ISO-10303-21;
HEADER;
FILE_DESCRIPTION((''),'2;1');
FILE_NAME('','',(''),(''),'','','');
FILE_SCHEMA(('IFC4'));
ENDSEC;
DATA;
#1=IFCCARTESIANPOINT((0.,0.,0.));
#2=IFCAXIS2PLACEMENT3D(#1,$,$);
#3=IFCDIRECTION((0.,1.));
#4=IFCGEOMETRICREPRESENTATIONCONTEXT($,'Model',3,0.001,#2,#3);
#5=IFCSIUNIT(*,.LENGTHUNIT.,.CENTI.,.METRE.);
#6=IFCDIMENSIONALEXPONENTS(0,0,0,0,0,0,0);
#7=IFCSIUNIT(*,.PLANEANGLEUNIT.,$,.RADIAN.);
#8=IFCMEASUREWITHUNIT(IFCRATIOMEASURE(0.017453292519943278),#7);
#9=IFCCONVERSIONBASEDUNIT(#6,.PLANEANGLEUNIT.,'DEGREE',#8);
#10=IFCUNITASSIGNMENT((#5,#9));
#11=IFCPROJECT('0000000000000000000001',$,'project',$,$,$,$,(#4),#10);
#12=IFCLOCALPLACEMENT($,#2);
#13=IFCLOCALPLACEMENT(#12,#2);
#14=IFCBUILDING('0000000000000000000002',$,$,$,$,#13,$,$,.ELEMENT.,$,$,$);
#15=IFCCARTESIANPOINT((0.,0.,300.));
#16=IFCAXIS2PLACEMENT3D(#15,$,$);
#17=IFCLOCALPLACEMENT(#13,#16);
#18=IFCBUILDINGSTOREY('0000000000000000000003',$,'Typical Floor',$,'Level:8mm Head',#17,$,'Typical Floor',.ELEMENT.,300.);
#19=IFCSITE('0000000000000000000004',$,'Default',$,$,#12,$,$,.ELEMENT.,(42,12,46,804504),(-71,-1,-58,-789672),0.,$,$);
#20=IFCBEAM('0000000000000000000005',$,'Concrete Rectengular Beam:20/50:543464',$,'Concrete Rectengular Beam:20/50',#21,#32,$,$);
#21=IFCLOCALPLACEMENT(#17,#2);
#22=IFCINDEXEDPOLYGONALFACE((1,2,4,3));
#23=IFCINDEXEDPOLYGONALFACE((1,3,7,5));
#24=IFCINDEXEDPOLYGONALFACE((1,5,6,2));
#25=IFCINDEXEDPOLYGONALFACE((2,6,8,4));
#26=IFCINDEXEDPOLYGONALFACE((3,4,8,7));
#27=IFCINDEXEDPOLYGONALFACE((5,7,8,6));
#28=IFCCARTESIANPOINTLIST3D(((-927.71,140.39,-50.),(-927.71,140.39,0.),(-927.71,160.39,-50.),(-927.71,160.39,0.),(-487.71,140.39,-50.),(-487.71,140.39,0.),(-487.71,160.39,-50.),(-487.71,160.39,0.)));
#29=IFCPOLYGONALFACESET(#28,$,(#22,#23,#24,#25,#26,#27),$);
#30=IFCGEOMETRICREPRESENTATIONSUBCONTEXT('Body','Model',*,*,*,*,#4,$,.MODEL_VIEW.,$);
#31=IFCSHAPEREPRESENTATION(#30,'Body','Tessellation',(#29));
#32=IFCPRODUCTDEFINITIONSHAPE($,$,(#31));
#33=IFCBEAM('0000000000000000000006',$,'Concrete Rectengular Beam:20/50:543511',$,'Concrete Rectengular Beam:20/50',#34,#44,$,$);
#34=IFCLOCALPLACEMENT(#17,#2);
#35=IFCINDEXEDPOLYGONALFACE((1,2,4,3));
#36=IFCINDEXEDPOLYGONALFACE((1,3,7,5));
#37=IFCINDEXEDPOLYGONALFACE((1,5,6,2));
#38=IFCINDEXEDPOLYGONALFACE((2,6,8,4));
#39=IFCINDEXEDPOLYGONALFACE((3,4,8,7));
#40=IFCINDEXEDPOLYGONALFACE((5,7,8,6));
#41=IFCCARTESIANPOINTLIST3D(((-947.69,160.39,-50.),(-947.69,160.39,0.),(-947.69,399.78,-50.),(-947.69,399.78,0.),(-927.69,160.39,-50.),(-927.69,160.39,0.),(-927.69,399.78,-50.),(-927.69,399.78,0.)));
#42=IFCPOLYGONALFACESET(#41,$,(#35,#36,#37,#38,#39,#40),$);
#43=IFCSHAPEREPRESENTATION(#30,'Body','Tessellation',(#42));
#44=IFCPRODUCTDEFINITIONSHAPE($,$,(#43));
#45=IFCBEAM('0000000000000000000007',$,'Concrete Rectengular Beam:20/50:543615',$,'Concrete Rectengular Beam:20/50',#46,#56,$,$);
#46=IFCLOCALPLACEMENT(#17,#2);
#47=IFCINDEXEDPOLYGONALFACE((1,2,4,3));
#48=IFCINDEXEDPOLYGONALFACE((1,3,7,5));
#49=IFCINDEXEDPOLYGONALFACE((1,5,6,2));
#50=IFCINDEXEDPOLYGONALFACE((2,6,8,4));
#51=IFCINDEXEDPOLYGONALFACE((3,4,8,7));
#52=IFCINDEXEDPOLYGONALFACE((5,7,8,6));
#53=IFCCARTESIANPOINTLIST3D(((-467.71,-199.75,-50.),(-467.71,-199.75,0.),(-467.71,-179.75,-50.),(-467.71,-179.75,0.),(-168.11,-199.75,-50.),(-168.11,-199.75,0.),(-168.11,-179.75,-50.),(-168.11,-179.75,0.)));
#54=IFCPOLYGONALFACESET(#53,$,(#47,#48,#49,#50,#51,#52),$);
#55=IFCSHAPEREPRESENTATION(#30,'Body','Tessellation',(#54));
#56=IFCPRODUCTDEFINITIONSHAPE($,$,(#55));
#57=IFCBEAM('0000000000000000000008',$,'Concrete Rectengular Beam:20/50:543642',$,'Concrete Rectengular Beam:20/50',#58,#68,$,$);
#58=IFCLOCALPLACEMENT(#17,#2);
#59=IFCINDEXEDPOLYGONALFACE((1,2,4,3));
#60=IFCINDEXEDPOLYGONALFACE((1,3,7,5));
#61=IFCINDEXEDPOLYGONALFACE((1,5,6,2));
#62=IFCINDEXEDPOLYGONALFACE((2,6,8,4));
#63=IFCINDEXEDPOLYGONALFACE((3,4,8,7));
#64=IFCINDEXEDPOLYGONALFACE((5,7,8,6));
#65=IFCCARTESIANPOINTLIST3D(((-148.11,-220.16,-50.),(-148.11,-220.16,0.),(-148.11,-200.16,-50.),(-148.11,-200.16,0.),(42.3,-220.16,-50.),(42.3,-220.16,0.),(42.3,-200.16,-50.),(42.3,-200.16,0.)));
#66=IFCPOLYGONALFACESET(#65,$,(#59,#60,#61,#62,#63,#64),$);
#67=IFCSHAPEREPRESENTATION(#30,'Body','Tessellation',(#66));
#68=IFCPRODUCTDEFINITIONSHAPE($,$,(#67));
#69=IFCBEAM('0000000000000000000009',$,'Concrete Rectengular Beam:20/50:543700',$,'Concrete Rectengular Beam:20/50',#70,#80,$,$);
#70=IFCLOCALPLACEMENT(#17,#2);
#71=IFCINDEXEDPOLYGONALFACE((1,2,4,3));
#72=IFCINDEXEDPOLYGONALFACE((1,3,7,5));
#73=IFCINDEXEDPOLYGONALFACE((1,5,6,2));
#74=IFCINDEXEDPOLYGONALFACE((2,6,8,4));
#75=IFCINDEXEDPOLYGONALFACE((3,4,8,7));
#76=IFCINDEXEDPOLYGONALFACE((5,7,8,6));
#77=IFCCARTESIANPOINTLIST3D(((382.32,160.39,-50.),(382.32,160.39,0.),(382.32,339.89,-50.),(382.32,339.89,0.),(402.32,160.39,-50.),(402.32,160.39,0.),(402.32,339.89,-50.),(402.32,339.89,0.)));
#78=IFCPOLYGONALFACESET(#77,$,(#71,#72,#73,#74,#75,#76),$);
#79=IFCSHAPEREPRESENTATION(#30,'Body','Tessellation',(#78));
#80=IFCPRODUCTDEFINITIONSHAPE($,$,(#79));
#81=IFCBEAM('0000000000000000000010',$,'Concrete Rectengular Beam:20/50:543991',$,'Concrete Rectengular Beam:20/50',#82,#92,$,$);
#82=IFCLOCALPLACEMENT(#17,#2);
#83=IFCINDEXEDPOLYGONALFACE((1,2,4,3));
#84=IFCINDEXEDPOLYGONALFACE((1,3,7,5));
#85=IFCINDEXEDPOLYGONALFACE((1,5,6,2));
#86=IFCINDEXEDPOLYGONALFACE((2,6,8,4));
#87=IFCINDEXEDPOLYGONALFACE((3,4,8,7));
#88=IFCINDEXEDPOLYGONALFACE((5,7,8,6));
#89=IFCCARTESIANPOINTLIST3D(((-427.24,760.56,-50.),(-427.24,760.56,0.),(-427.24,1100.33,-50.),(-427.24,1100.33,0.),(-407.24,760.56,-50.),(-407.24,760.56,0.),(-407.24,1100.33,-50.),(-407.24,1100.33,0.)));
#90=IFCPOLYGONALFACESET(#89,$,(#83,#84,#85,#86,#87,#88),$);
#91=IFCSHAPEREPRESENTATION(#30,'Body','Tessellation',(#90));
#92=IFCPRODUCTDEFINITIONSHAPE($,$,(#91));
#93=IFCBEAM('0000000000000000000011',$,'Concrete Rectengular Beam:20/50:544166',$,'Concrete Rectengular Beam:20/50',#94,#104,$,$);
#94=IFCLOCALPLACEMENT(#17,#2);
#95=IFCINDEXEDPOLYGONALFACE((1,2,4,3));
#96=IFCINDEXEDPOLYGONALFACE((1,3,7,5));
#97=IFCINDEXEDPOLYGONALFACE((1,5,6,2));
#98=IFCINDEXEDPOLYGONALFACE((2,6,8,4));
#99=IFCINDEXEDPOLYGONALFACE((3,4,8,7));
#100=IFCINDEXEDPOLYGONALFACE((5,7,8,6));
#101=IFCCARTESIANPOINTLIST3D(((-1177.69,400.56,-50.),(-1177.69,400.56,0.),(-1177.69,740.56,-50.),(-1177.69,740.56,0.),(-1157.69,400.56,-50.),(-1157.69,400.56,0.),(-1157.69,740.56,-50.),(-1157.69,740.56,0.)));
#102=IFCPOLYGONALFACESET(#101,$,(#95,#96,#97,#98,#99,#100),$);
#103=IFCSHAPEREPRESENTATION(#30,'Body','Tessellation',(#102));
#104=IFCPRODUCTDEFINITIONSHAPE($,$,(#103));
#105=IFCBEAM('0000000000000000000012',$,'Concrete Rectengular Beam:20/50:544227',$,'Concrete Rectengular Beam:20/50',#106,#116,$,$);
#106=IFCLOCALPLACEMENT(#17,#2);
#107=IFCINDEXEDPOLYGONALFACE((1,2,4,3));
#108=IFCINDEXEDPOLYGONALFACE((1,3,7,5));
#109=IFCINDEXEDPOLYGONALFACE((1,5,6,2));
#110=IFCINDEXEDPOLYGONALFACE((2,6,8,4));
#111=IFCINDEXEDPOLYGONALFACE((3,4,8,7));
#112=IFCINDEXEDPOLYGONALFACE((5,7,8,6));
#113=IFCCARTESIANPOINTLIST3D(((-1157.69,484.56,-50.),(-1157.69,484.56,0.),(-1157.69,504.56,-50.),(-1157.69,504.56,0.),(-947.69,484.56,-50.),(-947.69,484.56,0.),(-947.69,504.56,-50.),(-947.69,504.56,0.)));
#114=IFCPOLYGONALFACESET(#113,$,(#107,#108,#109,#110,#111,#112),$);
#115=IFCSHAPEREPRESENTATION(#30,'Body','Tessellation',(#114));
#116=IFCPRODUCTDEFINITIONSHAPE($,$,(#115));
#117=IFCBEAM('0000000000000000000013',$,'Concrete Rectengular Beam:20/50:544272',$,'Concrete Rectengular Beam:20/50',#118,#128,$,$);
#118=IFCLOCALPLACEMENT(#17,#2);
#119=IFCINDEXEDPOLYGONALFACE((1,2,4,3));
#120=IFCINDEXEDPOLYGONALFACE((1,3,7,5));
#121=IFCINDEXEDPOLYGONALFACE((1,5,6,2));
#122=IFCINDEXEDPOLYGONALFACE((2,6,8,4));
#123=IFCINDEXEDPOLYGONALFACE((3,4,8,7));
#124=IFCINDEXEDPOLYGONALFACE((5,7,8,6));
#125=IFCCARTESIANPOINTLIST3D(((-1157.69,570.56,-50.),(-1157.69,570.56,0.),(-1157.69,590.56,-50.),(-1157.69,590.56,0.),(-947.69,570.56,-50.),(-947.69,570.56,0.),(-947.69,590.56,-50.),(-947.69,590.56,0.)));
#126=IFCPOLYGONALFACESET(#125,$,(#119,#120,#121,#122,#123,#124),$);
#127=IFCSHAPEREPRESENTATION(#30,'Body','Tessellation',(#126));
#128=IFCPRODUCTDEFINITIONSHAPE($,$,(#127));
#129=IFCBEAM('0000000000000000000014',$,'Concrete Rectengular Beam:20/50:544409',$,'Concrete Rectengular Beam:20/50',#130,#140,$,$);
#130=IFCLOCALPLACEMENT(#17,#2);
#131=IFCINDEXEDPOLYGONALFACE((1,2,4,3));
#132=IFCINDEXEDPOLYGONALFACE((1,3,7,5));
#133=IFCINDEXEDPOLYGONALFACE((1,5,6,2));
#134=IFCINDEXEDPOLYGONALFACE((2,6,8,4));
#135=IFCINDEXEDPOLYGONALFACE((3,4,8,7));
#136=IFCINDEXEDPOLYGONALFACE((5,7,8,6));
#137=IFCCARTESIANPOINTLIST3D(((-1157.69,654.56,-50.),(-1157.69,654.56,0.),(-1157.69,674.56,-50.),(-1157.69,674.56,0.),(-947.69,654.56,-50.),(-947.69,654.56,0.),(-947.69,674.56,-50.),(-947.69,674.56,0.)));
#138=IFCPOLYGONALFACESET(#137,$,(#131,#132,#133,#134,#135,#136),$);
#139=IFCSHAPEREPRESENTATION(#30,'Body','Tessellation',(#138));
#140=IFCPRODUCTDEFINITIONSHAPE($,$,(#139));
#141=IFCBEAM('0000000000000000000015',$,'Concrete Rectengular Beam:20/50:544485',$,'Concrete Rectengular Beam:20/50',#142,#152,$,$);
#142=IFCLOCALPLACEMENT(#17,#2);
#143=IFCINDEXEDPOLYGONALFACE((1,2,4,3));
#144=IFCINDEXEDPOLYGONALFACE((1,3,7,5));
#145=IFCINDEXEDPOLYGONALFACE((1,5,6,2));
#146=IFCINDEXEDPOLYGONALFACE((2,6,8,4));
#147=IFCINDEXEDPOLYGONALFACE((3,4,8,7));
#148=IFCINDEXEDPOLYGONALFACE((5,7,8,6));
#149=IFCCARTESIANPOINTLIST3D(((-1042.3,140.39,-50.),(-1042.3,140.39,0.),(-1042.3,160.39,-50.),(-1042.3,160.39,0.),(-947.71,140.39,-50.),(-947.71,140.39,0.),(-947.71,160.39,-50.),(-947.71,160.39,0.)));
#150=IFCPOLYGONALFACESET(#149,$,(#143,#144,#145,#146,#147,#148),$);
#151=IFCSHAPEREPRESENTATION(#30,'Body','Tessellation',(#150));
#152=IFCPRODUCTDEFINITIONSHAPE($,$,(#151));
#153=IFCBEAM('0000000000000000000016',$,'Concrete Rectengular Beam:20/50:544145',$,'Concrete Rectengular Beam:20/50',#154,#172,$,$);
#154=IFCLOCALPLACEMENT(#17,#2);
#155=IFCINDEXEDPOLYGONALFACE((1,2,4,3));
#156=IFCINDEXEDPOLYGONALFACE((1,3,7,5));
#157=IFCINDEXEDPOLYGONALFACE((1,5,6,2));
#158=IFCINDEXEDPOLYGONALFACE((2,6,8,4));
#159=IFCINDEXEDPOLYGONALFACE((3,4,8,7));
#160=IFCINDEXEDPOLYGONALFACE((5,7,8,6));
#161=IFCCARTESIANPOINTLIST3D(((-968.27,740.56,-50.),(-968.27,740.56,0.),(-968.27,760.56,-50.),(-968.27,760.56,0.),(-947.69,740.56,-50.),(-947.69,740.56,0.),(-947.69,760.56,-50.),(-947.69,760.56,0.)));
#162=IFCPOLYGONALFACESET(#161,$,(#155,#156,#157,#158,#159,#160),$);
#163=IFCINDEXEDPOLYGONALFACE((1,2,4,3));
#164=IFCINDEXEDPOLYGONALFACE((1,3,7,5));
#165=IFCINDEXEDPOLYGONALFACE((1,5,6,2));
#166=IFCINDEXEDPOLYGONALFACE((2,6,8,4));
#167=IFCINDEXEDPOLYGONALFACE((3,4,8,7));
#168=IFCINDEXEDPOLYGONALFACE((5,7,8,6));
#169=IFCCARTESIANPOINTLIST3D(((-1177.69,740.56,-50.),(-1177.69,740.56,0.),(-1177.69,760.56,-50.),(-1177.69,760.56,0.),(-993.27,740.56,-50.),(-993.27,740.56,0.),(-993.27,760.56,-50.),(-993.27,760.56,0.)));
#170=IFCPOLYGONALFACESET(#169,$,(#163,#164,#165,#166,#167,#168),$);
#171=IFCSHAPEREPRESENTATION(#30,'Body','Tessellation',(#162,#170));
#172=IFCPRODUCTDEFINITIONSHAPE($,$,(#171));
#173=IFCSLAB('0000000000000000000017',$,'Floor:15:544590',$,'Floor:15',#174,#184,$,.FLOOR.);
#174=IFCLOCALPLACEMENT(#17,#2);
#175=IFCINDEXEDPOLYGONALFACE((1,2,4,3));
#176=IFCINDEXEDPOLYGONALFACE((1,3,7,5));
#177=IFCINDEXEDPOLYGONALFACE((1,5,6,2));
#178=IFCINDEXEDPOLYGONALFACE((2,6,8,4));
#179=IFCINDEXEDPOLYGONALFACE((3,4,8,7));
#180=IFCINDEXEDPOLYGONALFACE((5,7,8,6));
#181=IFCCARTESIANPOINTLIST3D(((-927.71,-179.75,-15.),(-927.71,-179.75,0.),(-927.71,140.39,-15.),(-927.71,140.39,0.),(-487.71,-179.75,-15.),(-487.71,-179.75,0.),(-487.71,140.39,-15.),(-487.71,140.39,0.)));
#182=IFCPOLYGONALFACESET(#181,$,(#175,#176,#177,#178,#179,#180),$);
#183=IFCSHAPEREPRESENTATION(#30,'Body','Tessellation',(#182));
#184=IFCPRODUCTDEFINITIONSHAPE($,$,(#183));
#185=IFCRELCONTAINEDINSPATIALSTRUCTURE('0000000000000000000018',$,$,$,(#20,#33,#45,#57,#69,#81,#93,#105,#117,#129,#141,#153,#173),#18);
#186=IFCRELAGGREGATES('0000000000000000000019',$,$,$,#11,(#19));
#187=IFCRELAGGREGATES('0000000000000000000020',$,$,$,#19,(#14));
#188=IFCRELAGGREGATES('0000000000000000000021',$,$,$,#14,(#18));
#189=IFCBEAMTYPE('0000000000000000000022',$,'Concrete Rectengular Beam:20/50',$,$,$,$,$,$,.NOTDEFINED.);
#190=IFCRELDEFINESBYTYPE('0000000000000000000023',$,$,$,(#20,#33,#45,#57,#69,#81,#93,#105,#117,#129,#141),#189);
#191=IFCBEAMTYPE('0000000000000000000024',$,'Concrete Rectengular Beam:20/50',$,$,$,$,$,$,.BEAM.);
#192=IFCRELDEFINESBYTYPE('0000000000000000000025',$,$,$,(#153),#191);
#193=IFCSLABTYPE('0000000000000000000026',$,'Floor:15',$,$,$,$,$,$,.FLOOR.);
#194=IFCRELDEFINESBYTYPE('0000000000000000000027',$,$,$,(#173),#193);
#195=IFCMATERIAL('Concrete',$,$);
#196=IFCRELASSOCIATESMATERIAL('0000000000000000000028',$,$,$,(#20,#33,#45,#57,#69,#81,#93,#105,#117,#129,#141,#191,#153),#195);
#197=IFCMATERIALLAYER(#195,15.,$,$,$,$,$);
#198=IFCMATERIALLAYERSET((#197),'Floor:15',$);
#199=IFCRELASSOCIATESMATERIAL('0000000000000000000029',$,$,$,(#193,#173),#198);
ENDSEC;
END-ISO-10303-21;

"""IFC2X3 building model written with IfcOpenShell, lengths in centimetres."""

from ifc_helpers import new_model, entity, si_unit, converted_unit, direction, frame, frame_2d, origin, place, context, subcontext, project, spatial, rectangle, extrude, source, transform, mapped, material, layer, layer_set, layer_usage, type_object, type_shapes, element, save


model = new_model("IFC2X3")

# Units and contexts
model_context = context("Model", 3, precision=0.001, world=origin(), true_north=direction((0.0, 1.0)))
body_context = subcontext(model_context, "Body", "Model", "MODEL_VIEW")
ifc_project = project(units=[si_unit("LENGTHUNIT", "METRE", prefix="CENTI"), converted_unit("PLANEANGLEUNIT", "DEGREE", entity("IfcRatioMeasure", 0.017453292519943278), si_unit("PLANEANGLEUNIT", "RADIAN"), dimensions=[0, 0, 0, 0, 0, 0, 0])], contexts=[model_context])

# Site, building, storey
site_placement = place(None, origin())
site = spatial("IfcSite", under=ifc_project, at=site_placement, Name="Default", CompositionType="ELEMENT", RefLatitude=(42, 12, 46, 804504), RefLongitude=(-71, -1, -58, -789672), RefElevation=0.0)
building_placement = place(site_placement, origin())
building = spatial("IfcBuilding", under=site, at=building_placement, CompositionType="ELEMENT")
storey_placement = place(building_placement, frame((0.0, 0.0, 300.0)))
storey = spatial("IfcBuildingStorey", under=building, at=storey_placement, Name="Typical Floor", ObjectType="Level:8mm Head", LongName="Typical Floor", CompositionType="ELEMENT", Elevation=300.0)

# Beams
ifc_material = material(Name="Concrete")
beam_type_1 = type_object("IfcBeamType", Name="Concrete Rectengular Beam:20/50", PredefinedType="NOTDEFINED")
beam_1_placement = place(storey_placement, frame((-477.71, 150.39, 0.0), z_axis=(0.0, 0.0, 1.0), x_axis=(-1.0, 0.0, 0.0)))
element("IfcBeam", 1, at=beam_1_placement, inside=storey, type_object=beam_type_1, material=ifc_material, Name="Concrete Rectengular Beam:20/50:543464", ObjectType="Concrete Rectengular Beam:20/50", context=body_context, shape_type="SweptSolid", body=[
    extrude(rectangle(XDim=50.0, YDim=20.0, at=frame_2d((0.0, 0.0), x_axis=(1.0, 0.0))), frame((10.0, 0.0, -25.0), z_axis=(1.0, 0.0, 0.0), x_axis=(0.0, 0.0, -1.0)), (0.0, 0.0, 1.0), 440.0),
])
beam_2_placement = place(storey_placement, frame((-937.69, 150.39, 0.0), z_axis=(0.0, 0.0, 1.0), x_axis=(0.0, 1.0, 0.0)))
element("IfcBeam", 2, at=beam_2_placement, inside=storey, type_object=beam_type_1, material=ifc_material, Name="Concrete Rectengular Beam:20/50:543511", ObjectType="Concrete Rectengular Beam:20/50", context=body_context, shape_type="SweptSolid", body=[
    extrude(rectangle(XDim=50.0, YDim=20.0, at=frame_2d((0.0, 0.0), x_axis=(1.0, 0.0))), frame((10.0, 0.0, -25.0), z_axis=(1.0, 0.0, 0.0), x_axis=(0.0, 0.0, -1.0)), (0.0, 0.0, 1.0), 239.39),
])
beam_3_placement = place(storey_placement, frame((-477.71, -189.75, 0.0)))
element("IfcBeam", 3, at=beam_3_placement, inside=storey, type_object=beam_type_1, material=ifc_material, Name="Concrete Rectengular Beam:20/50:543615", ObjectType="Concrete Rectengular Beam:20/50", context=body_context, shape_type="SweptSolid", body=[
    extrude(rectangle(XDim=50.0, YDim=20.0, at=frame_2d((0.0, 0.0), x_axis=(1.0, 0.0))), frame((10.0, 0.0, -25.0), z_axis=(1.0, 0.0, 0.0), x_axis=(0.0, 0.0, -1.0)), (0.0, 0.0, 1.0), 299.61),
])
beam_4_placement = place(storey_placement, frame((-158.11, -210.16, 0.0)))
element("IfcBeam", 4, at=beam_4_placement, inside=storey, type_object=beam_type_1, material=ifc_material, Name="Concrete Rectengular Beam:20/50:543642", ObjectType="Concrete Rectengular Beam:20/50", context=body_context, shape_type="SweptSolid", body=[
    extrude(rectangle(XDim=50.0, YDim=20.0, at=frame_2d((0.0, 0.0), x_axis=(1.0, 0.0))), frame((10.0, 0.0, -25.0), z_axis=(1.0, 0.0, 0.0), x_axis=(0.0, 0.0, -1.0)), (0.0, 0.0, 1.0), 190.41),
])
beam_5_placement = place(storey_placement, frame((392.32, 150.39, 0.0), z_axis=(0.0, 0.0, 1.0), x_axis=(0.0, 1.0, 0.0)))
element("IfcBeam", 5, at=beam_5_placement, inside=storey, type_object=beam_type_1, material=ifc_material, Name="Concrete Rectengular Beam:20/50:543700", ObjectType="Concrete Rectengular Beam:20/50", context=body_context, shape_type="SweptSolid", body=[
    extrude(rectangle(XDim=50.0, YDim=20.0, at=frame_2d((0.0, 0.0), x_axis=(1.0, 0.0))), frame((10.0, 0.0, -25.0), z_axis=(1.0, 0.0, 0.0), x_axis=(0.0, 0.0, -1.0)), (0.0, 0.0, 1.0), 179.5),
])
beam_6_placement = place(storey_placement, frame((-417.24, 750.56, 0.0), z_axis=(0.0, 0.0, 1.0), x_axis=(0.0, 1.0, 0.0)))
element("IfcBeam", 6, at=beam_6_placement, inside=storey, type_object=beam_type_1, material=ifc_material, Name="Concrete Rectengular Beam:20/50:543991", ObjectType="Concrete Rectengular Beam:20/50", context=body_context, shape_type="SweptSolid", body=[
    extrude(rectangle(XDim=50.0, YDim=20.0, at=frame_2d((0.0, 0.0), x_axis=(1.0, 0.0))), frame((10.0, 0.0, -25.0), z_axis=(1.0, 0.0, 0.0), x_axis=(0.0, 0.0, -1.0)), (0.0, 0.0, 1.0), 339.78),
])
beam_7_placement = place(storey_placement, frame((-1167.69, 750.56, 0.0), z_axis=(0.0, 0.0, 1.0), x_axis=(0.0, -1.0, 0.0)))
element("IfcBeam", 7, at=beam_7_placement, inside=storey, type_object=beam_type_1, material=ifc_material, Name="Concrete Rectengular Beam:20/50:544166", ObjectType="Concrete Rectengular Beam:20/50", context=body_context, shape_type="SweptSolid", body=[
    extrude(rectangle(XDim=50.0, YDim=20.0, at=frame_2d((0.0, 0.0), x_axis=(1.0, 0.0))), frame((10.0, 0.0, -25.0), z_axis=(1.0, 0.0, 0.0), x_axis=(0.0, 0.0, -1.0)), (0.0, 0.0, 1.0), 340.0),
])
beam_8_placement = place(storey_placement, frame((-937.69, 494.56, 0.0), z_axis=(0.0, 0.0, 1.0), x_axis=(-1.0, 0.0, 0.0)))
element("IfcBeam", 8, at=beam_8_placement, inside=storey, type_object=beam_type_1, material=ifc_material, Name="Concrete Rectengular Beam:20/50:544227", ObjectType="Concrete Rectengular Beam:20/50", context=body_context, shape_type="SweptSolid", body=[
    extrude(rectangle(XDim=50.0, YDim=20.0, at=frame_2d((0.0, 0.0), x_axis=(1.0, 0.0))), frame((10.0, 0.0, -25.0), z_axis=(1.0, 0.0, 0.0), x_axis=(0.0, 0.0, -1.0)), (0.0, 0.0, 1.0), 210.0),
])
for number, where, z_axis, x_axis, name in (
    (9, (-937.69, 580.56, 0.0), (0.0, 0.0, 1.0), (-1.0, 0.0, 0.0), "Concrete Rectengular Beam:20/50:544272"),
    (10, (-937.69, 664.56, 0.0), (0.0, 0.0, 1.0), (-1.0, 0.0, 0.0), "Concrete Rectengular Beam:20/50:544409"),
):
    element("IfcBeam", number, at=place(storey_placement, frame(where, z_axis=z_axis, x_axis=x_axis)), inside=storey, type_object=beam_type_1, material=ifc_material, Name=name, ObjectType="Concrete Rectengular Beam:20/50", context=body_context, shape_type="SweptSolid", body=[
        extrude(rectangle(XDim=50.0, YDim=20.0, at=frame_2d((0.0, 0.0), x_axis=(1.0, 0.0))), frame((10.0, 0.0, -25.0), z_axis=(1.0, 0.0, 0.0), x_axis=(0.0, 0.0, -1.0)), (0.0, 0.0, 1.0), 210.0),
    ])
beam_9_placement = place(storey_placement, frame((-937.71, 150.39, 0.0), z_axis=(0.0, 0.0, 1.0), x_axis=(-1.0, 0.0, 0.0)))
element("IfcBeam", 11, at=beam_9_placement, inside=storey, type_object=beam_type_1, material=ifc_material, Name="Concrete Rectengular Beam:20/50:544485", ObjectType="Concrete Rectengular Beam:20/50", context=body_context, shape_type="SweptSolid", body=[
    extrude(rectangle(XDim=50.0, YDim=20.0, at=frame_2d((0.0, 0.0), x_axis=(1.0, 0.0))), frame((10.0, 0.0, -25.0), z_axis=(1.0, 0.0, 0.0), x_axis=(0.0, 0.0, -1.0)), (0.0, 0.0, 1.0), 94.59),
])
beam_type_2 = type_object("IfcBeamType", Name="Concrete Rectengular Beam:20/50", PredefinedType="BEAM", material=ifc_material)
shared_shape = source(origin(), body_context, "Body", "SweptSolid", [
    extrude(rectangle(XDim=50.0, YDim=20.0, at=frame_2d((0.0, 0.0), x_axis=(1.0, 0.0))), frame((-947.69, 750.56, 275.0), z_axis=(-1.0, 0.0, 0.0), x_axis=(0.0, 0.0, -1.0)), (0.0, 0.0, 1.0), 20.58),
    extrude(rectangle(XDim=50.0, YDim=20.0, at=frame_2d((0.0, 0.0), x_axis=(1.0, 0.0))), frame((-993.27, 750.56, 275.0), z_axis=(-1.0, 0.0, 0.0), x_axis=(0.0, 0.0, -1.0)), (0.0, 0.0, 1.0), 184.42),
])
type_shapes(beam_type_2, [shared_shape])
beam_10_placement = place(storey_placement, frame((0.0, 0.0, -300.0)))
element("IfcBeam", 12, at=beam_10_placement, inside=storey, type_object=beam_type_2, material=ifc_material, Name="Concrete Rectengular Beam:20/50:544145", ObjectType="Concrete Rectengular Beam:20/50", context=body_context, shape_type="MappedRepresentation", body=[
    mapped(shared_shape, transform((0.0, 0.0, 0.0), scale=1.0)),
])

# Slab
ifc_layer = layer(ifc_material, 15.0)
ifc_layer_set = layer_set([ifc_layer], Name="Floor:15")
ifc_layer_usage_1 = layer_usage(ifc_layer_set, "AXIS3", "POSITIVE", 0.0)
slab_type_1 = type_object("IfcSlabType", Name="Floor:15", PredefinedType="FLOOR", material=ifc_layer_set)
slab_1_placement = place(storey_placement, origin())
element("IfcSlab", 13, at=slab_1_placement, inside=storey, type_object=slab_type_1, material=ifc_layer_usage_1, Name="Floor:15:544590", ObjectType="Floor:15", PredefinedType="FLOOR", context=body_context, shape_type="SweptSolid", body=[
    extrude(rectangle(XDim=320.13, YDim=440.0, at=frame_2d((0.0, 0.0), x_axis=(1.0, 0.0))), frame((-707.71, -19.68, 0.0), z_axis=(0.0, 0.0, -1.0), x_axis=(0.0, 1.0, 0.0)), (0.0, 0.0, 1.0), 15.0),
])

save(model, "model.ifc")
